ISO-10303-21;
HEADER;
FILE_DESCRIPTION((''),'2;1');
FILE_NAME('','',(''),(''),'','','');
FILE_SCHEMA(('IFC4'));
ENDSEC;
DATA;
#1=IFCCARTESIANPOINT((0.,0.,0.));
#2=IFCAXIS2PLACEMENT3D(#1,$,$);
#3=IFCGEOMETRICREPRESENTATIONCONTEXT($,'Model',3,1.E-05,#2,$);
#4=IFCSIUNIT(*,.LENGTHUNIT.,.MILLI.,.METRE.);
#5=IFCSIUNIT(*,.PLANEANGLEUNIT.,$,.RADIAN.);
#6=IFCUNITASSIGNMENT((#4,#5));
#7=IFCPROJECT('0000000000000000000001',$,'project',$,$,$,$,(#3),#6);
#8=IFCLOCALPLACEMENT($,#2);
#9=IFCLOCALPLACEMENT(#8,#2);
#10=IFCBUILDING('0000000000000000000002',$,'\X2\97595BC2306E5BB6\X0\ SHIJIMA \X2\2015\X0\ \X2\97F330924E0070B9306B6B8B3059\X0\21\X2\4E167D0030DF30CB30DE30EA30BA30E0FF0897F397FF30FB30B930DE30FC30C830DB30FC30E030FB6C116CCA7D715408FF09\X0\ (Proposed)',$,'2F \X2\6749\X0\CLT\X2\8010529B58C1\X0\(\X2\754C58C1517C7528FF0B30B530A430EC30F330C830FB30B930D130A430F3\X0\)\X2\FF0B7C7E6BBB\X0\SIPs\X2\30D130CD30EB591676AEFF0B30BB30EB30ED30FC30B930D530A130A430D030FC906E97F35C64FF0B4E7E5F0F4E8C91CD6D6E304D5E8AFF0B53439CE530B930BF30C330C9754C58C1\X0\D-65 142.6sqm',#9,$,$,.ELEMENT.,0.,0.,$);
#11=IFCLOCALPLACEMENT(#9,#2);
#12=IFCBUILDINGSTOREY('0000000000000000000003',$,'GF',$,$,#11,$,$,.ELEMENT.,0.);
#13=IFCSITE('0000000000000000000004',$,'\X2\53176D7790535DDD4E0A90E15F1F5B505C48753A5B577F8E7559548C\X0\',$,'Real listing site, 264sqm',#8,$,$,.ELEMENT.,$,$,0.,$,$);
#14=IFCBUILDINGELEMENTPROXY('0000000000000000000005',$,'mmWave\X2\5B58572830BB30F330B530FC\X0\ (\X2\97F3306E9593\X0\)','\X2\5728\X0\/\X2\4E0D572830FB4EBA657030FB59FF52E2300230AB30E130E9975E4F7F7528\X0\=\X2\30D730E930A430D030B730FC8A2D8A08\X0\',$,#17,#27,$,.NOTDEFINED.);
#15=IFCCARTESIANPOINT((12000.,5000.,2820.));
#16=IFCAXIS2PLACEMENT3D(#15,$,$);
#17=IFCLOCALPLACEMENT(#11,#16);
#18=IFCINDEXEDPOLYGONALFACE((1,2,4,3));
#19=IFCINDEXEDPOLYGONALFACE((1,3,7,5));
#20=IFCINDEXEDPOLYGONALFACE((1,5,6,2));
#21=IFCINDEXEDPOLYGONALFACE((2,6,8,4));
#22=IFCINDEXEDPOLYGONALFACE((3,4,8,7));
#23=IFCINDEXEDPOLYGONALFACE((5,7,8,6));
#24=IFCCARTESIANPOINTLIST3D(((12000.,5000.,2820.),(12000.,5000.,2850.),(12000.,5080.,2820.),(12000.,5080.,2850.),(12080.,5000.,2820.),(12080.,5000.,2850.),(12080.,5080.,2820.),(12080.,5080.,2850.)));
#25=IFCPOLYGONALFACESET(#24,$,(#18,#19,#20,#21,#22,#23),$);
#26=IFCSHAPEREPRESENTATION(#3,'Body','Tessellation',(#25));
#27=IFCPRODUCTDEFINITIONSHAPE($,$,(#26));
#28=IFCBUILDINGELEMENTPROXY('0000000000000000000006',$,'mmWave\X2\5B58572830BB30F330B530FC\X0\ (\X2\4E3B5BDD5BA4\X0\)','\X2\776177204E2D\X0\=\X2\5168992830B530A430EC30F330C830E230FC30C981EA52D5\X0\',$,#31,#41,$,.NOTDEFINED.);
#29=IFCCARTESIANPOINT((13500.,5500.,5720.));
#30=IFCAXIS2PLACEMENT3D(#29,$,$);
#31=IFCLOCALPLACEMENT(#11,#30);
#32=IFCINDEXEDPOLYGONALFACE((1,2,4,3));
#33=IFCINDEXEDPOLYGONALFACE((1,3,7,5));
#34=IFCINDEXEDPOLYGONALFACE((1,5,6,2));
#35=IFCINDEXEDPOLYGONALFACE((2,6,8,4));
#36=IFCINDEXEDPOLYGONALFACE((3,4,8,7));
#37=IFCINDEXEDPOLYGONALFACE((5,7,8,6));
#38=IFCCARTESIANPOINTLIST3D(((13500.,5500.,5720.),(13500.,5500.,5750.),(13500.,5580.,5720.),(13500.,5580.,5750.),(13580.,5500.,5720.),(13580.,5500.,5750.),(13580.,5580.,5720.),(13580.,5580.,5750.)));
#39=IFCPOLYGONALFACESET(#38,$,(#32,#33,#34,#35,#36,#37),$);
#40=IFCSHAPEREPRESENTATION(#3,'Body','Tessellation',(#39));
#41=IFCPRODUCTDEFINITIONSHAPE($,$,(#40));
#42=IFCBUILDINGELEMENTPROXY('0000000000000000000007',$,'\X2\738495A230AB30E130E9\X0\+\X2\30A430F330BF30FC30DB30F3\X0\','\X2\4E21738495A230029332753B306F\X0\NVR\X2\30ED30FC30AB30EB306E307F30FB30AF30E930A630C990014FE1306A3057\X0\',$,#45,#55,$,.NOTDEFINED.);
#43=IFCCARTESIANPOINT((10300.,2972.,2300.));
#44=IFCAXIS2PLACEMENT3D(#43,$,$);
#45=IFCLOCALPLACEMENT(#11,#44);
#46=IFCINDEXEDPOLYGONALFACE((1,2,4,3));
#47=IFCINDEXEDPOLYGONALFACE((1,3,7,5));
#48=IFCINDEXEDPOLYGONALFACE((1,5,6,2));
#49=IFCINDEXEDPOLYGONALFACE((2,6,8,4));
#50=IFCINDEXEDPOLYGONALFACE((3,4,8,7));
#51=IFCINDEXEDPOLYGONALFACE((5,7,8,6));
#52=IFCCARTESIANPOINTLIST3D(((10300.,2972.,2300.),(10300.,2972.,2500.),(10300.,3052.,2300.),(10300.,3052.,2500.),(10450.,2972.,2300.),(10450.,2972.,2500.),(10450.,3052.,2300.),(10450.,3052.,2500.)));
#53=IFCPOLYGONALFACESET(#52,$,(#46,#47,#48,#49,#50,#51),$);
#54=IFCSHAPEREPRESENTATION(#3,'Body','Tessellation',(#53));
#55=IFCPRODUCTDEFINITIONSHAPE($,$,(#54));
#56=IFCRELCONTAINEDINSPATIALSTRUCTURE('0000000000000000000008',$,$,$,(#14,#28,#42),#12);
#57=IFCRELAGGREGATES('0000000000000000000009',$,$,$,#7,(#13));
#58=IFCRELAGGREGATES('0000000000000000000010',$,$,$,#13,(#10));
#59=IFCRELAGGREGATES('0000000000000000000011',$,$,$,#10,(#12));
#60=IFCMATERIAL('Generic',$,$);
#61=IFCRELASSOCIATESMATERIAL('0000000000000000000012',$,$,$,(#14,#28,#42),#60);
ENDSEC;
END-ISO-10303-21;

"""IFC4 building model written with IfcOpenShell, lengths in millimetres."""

from ifc_helpers import new_model, si_unit, frame, frame_2d, origin, place, context, project, spatial, rectangle, extrude, material, element, save


model = new_model("IFC4")

# Units and contexts
model_context = context("Model", 3, precision=1e-05, world=origin())
ifc_project = project(units=[si_unit("LENGTHUNIT", "METRE", prefix="MILLI"), si_unit("PLANEANGLEUNIT", "RADIAN")], contexts=[model_context])

# Site, building, storey
site_placement = place(None, origin())
site = spatial("IfcSite", under=ifc_project, at=site_placement, Name="北海道川上郡弟子屈町字美留和", ObjectType="Real listing site, 264sqm", CompositionType="ELEMENT", RefElevation=0.0)
building_placement = place(site_placement, origin())
building = spatial("IfcBuilding", under=site, at=building_placement, Name="静寂の家 SHIJIMA ― 音を一点に残す21世紀ミニマリズム（音響・スマートホーム・民泊統合） (Proposed)", ObjectType="2F 杉CLT耐力壁(界壁兼用＋サイレント・スパイン)＋籾殻SIPsパネル外皮＋セルロースファイバー遮音層＋乾式二重浮き床＋千鳥スタッド界壁D-65 142.6sqm", CompositionType="ELEMENT", ElevationOfRefHeight=0.0, ElevationOfTerrain=0.0)
storey_placement = place(building_placement, origin())
storey = spatial("IfcBuildingStorey", under=building, at=storey_placement, Name="GF", CompositionType="ELEMENT", Elevation=0.0)

# Shared definitions
ifc_material = material(Name="Generic")

# Building element proxies
proxy_1_placement = place(storey_placement, frame((12000.0, 5000.0, 2820.0)))
element("IfcBuildingElementProxy", 1, at=proxy_1_placement, inside=storey, material=ifc_material, Name="mmWave存在センサー (音の間)", Description="在/不在・人数・姿勢。カメラ非使用=プライバシー設計", PredefinedType="NOTDEFINED", context=model_context, shape_type="SweptSolid", body=[
    extrude(rectangle(XDim=80.0, YDim=80.0, at=frame_2d((40.0, 40.0))), frame((12000.0, 5000.0, 2820.0)), (0.0, 0.0, 1.0), 30.0),
])
proxy_2_placement = place(storey_placement, frame((13500.0, 5500.0, 5720.0)))
element("IfcBuildingElementProxy", 2, at=proxy_2_placement, inside=storey, material=ifc_material, Name="mmWave存在センサー (主寝室)", Description="睡眠中=全館サイレントモード自動", PredefinedType="NOTDEFINED", context=model_context, shape_type="SweptSolid", body=[
    extrude(rectangle(XDim=80.0, YDim=80.0, at=frame_2d((40.0, 40.0))), frame((13500.0, 5500.0, 5720.0)), (0.0, 0.0, 1.0), 30.0),
])
proxy_3_placement = place(storey_placement, frame((10300.0, 2972.0, 2300.0)))
element("IfcBuildingElementProxy", 3, at=proxy_3_placement, inside=storey, material=ifc_material, Name="玄関カメラ+インターホン", Description="両玄関。録画はNVRローカルのみ・クラウド送信なし", PredefinedType="NOTDEFINED", context=model_context, shape_type="SweptSolid", body=[
    extrude(rectangle(XDim=150.0, YDim=80.0, at=frame_2d((75.0, 40.0))), frame((10300.0, 2972.0, 2300.0)), (0.0, 0.0, 1.0), 200.0),
])

save(model, "model.ifc")
